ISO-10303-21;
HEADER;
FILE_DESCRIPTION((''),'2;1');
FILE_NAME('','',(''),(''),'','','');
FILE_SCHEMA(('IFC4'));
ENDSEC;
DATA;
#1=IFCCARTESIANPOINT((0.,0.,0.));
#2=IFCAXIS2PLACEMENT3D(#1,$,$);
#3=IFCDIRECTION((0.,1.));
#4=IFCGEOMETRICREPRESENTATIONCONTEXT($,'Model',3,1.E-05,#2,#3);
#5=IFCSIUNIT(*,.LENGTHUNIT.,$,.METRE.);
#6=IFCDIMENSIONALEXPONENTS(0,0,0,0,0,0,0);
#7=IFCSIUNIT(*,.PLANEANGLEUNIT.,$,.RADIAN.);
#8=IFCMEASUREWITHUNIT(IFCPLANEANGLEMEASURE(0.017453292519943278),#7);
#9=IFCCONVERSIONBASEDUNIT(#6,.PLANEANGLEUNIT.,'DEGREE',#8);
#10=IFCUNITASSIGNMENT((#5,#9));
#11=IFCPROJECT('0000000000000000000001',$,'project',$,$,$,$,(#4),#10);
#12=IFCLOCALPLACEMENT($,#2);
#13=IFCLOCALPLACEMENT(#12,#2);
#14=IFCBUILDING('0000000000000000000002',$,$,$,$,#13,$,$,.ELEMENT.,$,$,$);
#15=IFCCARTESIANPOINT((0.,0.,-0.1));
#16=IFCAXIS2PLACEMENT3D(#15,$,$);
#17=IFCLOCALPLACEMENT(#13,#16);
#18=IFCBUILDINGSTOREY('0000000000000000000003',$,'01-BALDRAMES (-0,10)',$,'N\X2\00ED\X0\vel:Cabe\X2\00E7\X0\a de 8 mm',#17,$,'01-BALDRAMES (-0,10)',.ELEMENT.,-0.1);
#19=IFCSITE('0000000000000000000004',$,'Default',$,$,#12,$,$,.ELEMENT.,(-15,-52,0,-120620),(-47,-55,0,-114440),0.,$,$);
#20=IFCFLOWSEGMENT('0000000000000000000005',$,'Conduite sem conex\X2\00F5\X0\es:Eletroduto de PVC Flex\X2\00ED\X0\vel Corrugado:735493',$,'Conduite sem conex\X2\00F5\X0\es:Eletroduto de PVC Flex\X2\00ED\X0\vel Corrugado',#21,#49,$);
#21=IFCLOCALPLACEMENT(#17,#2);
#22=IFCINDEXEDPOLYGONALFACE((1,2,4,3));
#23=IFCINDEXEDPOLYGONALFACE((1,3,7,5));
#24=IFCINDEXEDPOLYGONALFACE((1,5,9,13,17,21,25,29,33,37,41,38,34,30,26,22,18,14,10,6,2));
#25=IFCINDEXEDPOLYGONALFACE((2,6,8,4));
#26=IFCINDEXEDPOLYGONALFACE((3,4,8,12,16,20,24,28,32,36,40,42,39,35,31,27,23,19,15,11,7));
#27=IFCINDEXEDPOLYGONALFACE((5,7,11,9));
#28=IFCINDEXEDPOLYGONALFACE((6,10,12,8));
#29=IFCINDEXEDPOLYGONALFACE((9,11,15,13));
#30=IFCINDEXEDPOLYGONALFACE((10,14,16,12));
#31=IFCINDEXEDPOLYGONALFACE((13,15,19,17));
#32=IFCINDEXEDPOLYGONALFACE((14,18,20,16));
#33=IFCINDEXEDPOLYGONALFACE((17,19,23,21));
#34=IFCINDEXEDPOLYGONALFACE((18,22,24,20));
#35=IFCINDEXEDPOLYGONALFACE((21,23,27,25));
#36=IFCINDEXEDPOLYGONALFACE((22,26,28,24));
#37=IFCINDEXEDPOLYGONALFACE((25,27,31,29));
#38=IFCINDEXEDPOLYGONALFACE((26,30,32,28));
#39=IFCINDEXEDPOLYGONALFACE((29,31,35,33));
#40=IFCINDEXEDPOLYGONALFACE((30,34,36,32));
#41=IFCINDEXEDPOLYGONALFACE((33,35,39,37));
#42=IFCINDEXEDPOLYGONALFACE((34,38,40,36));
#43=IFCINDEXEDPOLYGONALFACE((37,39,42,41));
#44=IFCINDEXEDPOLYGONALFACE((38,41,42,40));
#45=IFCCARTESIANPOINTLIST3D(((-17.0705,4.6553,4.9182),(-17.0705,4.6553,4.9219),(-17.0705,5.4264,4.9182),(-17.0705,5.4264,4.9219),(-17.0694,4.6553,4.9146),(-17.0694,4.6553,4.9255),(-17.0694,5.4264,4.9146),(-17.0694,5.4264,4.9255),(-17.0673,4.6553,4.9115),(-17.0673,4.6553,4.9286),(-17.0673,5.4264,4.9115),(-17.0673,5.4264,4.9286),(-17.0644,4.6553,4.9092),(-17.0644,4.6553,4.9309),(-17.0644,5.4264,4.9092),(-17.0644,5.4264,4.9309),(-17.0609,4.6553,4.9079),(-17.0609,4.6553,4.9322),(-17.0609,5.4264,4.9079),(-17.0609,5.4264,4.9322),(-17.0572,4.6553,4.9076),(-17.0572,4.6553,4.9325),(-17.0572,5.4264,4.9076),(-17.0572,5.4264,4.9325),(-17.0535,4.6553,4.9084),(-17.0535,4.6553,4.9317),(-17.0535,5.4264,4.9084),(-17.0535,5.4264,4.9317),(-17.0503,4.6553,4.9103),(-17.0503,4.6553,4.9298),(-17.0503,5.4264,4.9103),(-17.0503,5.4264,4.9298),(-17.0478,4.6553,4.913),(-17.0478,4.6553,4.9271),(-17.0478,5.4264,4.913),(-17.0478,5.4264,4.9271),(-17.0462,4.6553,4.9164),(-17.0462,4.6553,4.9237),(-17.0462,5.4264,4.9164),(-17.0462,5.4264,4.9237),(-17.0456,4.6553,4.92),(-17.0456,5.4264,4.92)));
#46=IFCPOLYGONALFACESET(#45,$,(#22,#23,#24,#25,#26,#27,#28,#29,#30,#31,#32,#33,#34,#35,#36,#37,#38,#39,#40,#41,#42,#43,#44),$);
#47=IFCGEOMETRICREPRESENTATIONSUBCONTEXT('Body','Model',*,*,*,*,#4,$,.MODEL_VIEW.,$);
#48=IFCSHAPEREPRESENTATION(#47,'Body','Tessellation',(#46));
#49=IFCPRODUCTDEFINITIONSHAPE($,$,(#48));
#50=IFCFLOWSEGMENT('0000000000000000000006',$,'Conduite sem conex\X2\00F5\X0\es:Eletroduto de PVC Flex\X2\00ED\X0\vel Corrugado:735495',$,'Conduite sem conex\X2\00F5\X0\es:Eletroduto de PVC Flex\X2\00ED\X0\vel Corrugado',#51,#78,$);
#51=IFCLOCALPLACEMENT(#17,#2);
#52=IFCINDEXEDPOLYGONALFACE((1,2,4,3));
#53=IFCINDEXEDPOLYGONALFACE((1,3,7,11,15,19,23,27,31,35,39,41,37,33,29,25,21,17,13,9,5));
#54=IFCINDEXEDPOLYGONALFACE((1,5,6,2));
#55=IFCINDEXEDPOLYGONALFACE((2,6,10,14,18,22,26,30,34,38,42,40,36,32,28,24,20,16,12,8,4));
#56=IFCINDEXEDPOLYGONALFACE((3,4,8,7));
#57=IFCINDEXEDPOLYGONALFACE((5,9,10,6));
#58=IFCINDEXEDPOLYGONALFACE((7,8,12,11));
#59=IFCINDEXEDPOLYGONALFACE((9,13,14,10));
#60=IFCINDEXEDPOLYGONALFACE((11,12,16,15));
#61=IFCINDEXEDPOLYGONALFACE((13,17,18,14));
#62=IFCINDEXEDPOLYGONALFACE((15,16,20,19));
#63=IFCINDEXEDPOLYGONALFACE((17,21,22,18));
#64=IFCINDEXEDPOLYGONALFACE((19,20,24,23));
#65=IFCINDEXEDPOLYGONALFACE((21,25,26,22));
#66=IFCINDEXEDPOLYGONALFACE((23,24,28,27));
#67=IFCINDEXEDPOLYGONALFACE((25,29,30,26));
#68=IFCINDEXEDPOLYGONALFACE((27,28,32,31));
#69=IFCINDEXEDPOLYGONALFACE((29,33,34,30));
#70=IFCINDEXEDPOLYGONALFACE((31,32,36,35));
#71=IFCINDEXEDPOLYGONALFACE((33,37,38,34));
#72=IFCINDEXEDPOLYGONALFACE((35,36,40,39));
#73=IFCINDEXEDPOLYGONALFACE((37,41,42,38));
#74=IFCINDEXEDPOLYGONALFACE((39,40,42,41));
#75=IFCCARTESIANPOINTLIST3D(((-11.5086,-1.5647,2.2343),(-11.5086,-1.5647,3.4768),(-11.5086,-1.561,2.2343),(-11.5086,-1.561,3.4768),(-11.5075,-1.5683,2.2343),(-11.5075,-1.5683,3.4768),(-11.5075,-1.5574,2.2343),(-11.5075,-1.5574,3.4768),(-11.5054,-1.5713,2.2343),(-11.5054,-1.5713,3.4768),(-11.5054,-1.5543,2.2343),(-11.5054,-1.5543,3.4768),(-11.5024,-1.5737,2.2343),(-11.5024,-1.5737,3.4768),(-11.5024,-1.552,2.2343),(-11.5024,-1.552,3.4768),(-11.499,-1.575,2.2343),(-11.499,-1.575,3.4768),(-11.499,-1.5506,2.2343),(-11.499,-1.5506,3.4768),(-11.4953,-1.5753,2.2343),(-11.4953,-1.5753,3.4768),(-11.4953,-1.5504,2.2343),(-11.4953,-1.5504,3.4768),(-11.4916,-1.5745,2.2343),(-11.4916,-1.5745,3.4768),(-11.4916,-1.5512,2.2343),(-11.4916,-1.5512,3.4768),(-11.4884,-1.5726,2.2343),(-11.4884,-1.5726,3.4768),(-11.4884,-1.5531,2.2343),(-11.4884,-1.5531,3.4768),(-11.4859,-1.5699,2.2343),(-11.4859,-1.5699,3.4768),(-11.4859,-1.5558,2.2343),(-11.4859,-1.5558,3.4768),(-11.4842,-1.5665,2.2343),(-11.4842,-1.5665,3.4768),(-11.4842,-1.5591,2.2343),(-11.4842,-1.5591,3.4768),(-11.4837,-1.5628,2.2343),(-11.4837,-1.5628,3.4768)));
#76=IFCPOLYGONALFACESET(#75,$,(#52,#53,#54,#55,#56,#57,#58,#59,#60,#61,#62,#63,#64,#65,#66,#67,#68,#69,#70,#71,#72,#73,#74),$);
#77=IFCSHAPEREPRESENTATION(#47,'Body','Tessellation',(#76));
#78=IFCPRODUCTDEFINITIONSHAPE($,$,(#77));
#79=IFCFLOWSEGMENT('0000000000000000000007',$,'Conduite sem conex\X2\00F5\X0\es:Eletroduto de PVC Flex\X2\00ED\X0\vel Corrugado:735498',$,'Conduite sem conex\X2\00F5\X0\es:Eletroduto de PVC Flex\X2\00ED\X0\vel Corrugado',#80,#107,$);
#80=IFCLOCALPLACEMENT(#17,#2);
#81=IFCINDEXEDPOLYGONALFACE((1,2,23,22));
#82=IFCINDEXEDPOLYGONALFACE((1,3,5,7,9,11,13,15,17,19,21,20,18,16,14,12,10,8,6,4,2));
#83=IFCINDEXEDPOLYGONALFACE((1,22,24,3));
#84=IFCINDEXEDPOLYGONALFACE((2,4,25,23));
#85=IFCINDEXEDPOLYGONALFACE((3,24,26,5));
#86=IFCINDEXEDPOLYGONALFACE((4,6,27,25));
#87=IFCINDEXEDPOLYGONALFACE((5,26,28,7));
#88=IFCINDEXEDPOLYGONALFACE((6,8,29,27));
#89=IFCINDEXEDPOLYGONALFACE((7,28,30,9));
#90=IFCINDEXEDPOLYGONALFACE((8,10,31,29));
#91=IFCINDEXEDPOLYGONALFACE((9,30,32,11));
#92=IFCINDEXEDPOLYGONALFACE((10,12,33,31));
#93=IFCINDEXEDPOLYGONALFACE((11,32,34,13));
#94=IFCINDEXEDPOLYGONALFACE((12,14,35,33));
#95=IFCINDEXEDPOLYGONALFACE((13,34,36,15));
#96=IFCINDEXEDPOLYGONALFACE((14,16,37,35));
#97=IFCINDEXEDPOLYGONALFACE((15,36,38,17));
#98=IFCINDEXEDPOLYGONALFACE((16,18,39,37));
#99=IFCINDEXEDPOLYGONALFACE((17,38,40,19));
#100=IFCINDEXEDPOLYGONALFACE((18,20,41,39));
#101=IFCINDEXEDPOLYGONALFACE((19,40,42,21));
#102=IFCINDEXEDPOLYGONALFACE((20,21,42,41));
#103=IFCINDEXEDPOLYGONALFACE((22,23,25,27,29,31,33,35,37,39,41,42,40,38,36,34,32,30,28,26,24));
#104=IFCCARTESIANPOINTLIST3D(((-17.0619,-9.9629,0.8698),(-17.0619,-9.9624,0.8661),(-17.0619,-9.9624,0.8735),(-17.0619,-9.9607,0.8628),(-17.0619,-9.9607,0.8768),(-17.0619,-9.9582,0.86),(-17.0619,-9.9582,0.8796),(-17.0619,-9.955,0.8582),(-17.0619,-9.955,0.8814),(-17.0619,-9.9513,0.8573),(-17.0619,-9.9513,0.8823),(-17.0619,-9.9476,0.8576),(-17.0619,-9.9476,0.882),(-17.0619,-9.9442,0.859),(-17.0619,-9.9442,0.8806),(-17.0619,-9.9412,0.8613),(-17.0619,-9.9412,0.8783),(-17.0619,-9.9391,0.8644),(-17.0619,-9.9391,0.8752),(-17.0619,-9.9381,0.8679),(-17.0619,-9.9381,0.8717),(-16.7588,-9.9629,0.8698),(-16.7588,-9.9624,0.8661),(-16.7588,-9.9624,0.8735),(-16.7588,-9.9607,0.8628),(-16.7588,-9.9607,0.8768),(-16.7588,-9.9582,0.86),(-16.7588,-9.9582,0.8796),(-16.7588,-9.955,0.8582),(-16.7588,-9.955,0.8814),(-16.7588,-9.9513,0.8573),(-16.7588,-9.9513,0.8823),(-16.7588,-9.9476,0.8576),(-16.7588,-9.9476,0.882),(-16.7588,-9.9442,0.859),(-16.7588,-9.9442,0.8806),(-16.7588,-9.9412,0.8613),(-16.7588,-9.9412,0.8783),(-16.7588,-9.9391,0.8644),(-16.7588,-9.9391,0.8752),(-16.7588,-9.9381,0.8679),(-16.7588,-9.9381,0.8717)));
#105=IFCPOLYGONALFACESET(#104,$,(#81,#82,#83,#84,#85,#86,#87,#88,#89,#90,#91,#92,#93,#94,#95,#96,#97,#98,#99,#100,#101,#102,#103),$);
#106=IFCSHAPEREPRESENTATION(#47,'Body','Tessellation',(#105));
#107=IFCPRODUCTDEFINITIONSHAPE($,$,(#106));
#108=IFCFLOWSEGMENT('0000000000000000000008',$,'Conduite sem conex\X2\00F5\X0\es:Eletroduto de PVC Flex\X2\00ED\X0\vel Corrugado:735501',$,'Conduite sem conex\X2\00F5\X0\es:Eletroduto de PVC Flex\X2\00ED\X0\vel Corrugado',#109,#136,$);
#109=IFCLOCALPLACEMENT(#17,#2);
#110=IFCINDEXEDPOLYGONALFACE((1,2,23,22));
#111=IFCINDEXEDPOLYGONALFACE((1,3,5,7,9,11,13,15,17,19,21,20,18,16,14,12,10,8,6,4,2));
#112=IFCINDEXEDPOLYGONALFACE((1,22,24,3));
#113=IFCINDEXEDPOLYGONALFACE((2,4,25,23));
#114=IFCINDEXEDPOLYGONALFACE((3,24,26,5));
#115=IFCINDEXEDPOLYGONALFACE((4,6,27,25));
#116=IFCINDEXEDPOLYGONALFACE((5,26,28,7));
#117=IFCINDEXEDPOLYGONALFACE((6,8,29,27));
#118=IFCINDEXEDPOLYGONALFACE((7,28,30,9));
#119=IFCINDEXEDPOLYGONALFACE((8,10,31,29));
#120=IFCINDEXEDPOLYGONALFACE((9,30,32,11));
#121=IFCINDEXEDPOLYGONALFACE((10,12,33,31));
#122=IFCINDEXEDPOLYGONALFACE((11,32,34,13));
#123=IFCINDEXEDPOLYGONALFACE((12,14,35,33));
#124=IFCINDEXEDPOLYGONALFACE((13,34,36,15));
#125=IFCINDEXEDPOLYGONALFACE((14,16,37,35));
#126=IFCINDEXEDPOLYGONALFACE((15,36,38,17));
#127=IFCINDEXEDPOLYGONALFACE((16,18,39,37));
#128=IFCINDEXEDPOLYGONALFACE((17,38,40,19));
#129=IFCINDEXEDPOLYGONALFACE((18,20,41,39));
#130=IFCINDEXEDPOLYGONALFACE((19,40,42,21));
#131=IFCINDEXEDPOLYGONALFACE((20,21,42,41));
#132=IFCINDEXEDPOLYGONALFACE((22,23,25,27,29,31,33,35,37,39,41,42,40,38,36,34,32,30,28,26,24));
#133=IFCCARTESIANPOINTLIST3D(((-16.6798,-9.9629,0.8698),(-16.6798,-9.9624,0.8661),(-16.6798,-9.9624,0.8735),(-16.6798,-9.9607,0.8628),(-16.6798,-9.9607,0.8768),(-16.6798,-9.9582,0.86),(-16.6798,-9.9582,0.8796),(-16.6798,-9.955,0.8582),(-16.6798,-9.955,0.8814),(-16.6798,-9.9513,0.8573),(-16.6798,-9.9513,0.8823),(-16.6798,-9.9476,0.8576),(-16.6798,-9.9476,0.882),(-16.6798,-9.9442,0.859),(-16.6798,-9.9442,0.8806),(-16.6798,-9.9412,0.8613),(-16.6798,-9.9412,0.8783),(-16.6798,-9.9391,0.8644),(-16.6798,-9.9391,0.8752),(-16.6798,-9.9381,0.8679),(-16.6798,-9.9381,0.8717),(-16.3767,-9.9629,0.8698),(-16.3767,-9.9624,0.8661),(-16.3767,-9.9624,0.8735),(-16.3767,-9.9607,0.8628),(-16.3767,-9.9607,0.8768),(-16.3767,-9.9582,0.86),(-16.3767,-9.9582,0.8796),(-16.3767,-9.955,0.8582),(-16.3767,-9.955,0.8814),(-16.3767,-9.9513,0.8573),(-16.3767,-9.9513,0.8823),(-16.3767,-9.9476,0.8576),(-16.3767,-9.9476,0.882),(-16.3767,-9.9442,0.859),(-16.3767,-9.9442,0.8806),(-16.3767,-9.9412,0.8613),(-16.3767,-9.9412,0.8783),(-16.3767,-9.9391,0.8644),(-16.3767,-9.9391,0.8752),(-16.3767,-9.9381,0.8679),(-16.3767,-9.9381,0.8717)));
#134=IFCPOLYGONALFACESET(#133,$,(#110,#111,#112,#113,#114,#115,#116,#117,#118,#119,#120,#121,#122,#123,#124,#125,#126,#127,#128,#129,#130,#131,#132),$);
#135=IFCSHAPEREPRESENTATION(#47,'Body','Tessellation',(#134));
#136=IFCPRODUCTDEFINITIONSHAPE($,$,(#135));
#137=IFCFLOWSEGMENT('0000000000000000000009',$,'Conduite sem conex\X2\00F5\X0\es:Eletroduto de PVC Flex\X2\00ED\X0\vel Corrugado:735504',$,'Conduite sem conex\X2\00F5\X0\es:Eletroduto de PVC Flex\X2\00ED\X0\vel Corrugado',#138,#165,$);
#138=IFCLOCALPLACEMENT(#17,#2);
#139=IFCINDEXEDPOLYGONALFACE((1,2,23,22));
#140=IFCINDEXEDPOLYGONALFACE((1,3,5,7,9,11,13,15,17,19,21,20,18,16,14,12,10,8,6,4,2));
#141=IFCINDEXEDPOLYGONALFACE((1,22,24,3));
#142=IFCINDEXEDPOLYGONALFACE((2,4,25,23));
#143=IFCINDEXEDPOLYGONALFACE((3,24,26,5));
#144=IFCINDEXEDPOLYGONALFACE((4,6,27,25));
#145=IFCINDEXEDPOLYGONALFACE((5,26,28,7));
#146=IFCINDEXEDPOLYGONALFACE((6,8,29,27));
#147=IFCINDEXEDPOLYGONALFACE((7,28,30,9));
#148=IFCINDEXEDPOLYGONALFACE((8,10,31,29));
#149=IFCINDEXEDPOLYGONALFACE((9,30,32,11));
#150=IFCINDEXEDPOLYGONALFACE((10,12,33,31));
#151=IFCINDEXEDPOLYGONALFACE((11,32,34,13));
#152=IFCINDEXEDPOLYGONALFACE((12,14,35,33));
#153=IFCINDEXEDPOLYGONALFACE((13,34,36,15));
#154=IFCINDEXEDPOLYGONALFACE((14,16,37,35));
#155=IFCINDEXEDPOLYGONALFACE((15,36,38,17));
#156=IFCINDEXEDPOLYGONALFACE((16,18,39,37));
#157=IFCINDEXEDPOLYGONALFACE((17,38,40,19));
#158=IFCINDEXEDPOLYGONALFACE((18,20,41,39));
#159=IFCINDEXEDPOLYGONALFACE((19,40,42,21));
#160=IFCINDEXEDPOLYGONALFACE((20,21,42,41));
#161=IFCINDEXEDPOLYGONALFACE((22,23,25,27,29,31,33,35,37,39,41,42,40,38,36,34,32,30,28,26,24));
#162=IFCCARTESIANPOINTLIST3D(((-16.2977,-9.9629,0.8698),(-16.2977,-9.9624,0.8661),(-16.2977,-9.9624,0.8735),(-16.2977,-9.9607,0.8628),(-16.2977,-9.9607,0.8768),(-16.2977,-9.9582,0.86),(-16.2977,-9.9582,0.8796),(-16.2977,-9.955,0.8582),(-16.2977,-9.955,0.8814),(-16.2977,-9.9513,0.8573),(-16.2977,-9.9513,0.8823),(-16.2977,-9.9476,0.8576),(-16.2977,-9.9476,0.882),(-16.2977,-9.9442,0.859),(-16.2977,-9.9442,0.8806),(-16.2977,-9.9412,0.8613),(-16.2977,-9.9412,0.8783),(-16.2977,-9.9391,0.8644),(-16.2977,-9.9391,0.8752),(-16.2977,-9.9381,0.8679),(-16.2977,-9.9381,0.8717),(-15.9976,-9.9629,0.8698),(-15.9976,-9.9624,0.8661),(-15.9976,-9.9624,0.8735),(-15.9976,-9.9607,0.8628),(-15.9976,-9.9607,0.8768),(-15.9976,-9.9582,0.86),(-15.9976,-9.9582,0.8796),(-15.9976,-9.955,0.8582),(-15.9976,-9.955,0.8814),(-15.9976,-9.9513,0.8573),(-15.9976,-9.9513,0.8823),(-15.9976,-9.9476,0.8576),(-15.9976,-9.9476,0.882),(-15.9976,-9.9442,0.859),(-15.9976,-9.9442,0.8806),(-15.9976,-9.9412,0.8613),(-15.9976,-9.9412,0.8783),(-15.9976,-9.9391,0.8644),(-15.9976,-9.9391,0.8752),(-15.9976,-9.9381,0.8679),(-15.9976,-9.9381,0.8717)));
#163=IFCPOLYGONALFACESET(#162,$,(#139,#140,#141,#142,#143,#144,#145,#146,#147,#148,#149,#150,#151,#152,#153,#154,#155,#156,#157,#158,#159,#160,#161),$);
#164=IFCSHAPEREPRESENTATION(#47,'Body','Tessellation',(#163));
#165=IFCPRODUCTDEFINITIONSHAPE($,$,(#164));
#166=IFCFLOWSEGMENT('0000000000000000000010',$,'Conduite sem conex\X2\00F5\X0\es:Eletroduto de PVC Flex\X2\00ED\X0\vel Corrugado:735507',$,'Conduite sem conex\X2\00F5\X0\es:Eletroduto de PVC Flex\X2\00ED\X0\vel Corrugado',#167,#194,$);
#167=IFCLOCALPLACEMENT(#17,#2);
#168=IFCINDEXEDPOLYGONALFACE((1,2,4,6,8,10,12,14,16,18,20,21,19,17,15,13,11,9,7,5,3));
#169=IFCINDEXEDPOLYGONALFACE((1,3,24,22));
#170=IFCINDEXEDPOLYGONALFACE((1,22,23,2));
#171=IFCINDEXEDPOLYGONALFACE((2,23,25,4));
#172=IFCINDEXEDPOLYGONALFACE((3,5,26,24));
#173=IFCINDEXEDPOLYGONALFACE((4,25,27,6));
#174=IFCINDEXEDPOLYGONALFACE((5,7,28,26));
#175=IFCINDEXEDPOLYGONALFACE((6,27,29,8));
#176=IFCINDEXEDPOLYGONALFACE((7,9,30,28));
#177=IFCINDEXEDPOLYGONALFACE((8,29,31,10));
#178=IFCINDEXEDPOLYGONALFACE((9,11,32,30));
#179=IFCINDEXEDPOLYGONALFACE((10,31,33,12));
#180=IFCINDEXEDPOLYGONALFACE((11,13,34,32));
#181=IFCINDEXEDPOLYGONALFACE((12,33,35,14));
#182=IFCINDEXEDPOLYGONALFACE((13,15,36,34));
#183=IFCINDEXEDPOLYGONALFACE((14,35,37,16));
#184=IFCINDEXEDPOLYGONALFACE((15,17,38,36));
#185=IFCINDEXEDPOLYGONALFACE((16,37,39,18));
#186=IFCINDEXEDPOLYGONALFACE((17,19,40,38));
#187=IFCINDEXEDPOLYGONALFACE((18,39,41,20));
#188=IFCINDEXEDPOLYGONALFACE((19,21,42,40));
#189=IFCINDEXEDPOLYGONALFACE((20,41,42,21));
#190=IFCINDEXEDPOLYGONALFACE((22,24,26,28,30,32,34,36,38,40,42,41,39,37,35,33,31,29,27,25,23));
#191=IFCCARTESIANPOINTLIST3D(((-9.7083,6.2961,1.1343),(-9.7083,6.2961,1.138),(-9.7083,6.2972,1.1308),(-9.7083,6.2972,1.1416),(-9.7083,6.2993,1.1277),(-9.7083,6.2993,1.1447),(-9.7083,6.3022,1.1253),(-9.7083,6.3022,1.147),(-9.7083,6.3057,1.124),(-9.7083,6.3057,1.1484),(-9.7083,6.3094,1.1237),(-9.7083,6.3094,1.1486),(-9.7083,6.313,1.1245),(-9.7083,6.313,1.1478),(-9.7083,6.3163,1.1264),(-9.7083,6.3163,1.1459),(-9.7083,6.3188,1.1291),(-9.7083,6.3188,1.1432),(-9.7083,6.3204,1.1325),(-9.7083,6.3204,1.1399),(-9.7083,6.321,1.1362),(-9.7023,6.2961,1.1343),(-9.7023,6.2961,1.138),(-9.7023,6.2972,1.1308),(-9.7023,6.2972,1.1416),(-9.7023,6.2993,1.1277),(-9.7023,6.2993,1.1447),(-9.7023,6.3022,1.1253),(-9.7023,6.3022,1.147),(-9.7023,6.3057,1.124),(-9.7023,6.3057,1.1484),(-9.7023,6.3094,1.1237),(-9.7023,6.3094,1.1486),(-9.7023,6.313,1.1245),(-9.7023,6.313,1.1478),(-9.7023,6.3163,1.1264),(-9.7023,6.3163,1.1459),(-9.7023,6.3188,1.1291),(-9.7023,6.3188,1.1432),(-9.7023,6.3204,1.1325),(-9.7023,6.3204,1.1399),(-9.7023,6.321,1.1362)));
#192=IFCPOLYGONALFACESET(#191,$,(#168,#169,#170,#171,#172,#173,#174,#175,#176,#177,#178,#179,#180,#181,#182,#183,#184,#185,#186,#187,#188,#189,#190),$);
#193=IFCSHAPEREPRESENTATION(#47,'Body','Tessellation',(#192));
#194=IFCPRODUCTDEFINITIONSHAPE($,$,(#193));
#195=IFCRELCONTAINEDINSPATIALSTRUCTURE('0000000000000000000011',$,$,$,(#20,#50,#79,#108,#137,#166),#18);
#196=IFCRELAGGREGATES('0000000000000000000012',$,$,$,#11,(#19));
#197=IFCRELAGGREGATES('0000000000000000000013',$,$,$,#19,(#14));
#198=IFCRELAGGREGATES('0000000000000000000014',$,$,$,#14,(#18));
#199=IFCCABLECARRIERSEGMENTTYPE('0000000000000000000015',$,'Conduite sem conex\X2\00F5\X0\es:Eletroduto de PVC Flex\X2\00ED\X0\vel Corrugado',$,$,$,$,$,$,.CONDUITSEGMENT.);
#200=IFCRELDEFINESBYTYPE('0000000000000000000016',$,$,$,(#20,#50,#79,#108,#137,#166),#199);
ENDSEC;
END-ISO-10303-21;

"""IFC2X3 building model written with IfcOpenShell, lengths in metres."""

from ifc_helpers import new_model, entity, si_unit, converted_unit, direction, frame, origin, origin_2d_with_axis, place, context, subcontext, project, spatial, circle, extrude, type_object, element, save


model = new_model("IFC2X3")

# Units and contexts
model_context = context("Model", 3, precision=1e-05, world=origin(), true_north=direction((0.0, 1.0)))
body_context = subcontext(model_context, "Body", "Model", "MODEL_VIEW")
ifc_project = project(units=[si_unit("LENGTHUNIT", "METRE"), converted_unit("PLANEANGLEUNIT", "DEGREE", entity("IfcPlaneAngleMeasure", 0.017453292519943278), si_unit("PLANEANGLEUNIT", "RADIAN"), dimensions=[0, 0, 0, 0, 0, 0, 0])], contexts=[model_context])

# Site, building, storey
site_placement = place(None, origin())
site = spatial("IfcSite", under=ifc_project, at=site_placement, Name="Default", CompositionType="ELEMENT", RefLatitude=(-15, -52, 0, -120620), RefLongitude=(-47, -55, 0, -114440), RefElevation=0.0)
building_placement = place(site_placement, origin())
building = spatial("IfcBuilding", under=site, at=building_placement, CompositionType="ELEMENT")
storey_placement = place(building_placement, frame((0.0, 0.0, -0.1)))
storey = spatial("IfcBuildingStorey", under=building, at=storey_placement, Name="01-BALDRAMES (-0,10)", ObjectType="Nível:Cabeça de 8 mm", LongName="01-BALDRAMES (-0,10)", CompositionType="ELEMENT", Elevation=-0.1)

# Flow segments
cable_carrier_segment_type = type_object("IfcCableCarrierSegmentType", Name="Conduite sem conexões:Eletroduto de PVC Flexível Corrugado", PredefinedType="CONDUITSEGMENT")
flow_segment_1_placement = place(storey_placement, origin())
element("IfcFlowSegment", 1, at=flow_segment_1_placement, inside=storey, type_object=cable_carrier_segment_type, Name="Conduite sem conexões:Eletroduto de PVC Flexível Corrugado:735493", ObjectType="Conduite sem conexões:Eletroduto de PVC Flexível Corrugado", context=body_context, shape_type="SweptSolid", body=[
    extrude(circle(Radius=0.0125, at=origin_2d_with_axis()), frame((-17.0581, 4.6553, 4.92), z_axis=(0.0, 1.0, 0.0), x_axis=(1.0, 0.0, 0.0)), (0.0, 0.0, 1.0), 0.771),
])
flow_segment_2_placement = place(storey_placement, origin())
element("IfcFlowSegment", 2, at=flow_segment_2_placement, inside=storey, type_object=cable_carrier_segment_type, Name="Conduite sem conexões:Eletroduto de PVC Flexível Corrugado:735495", ObjectType="Conduite sem conexões:Eletroduto de PVC Flexível Corrugado", context=body_context, shape_type="SweptSolid", body=[
    extrude(circle(Radius=0.0125, at=origin_2d_with_axis()), frame((-11.4962, -1.5628, 2.2343)), (0.0, 0.0, 1.0), 1.2425),
])
flow_segment_3_placement = place(storey_placement, origin())
element("IfcFlowSegment", 3, at=flow_segment_3_placement, inside=storey, type_object=cable_carrier_segment_type, Name="Conduite sem conexões:Eletroduto de PVC Flexível Corrugado:735498", ObjectType="Conduite sem conexões:Eletroduto de PVC Flexível Corrugado", context=body_context, shape_type="SweptSolid", body=[
    extrude(circle(Radius=0.0125, at=origin_2d_with_axis()), frame((-17.0619, -9.9504, 0.8698), z_axis=(1.0, 0.0, 0.0), x_axis=(0.0, -1.0, 0.0)), (0.0, 0.0, 1.0), 0.3031),
])
flow_segment_4_placement = place(storey_placement, origin())
element("IfcFlowSegment", 4, at=flow_segment_4_placement, inside=storey, type_object=cable_carrier_segment_type, Name="Conduite sem conexões:Eletroduto de PVC Flexível Corrugado:735501", ObjectType="Conduite sem conexões:Eletroduto de PVC Flexível Corrugado", context=body_context, shape_type="SweptSolid", body=[
    extrude(circle(Radius=0.0125, at=origin_2d_with_axis()), frame((-16.6798, -9.9504, 0.8698), z_axis=(1.0, 0.0, 0.0), x_axis=(0.0, -1.0, 0.0)), (0.0, 0.0, 1.0), 0.3031),
])
flow_segment_5_placement = place(storey_placement, origin())
element("IfcFlowSegment", 5, at=flow_segment_5_placement, inside=storey, type_object=cable_carrier_segment_type, Name="Conduite sem conexões:Eletroduto de PVC Flexível Corrugado:735504", ObjectType="Conduite sem conexões:Eletroduto de PVC Flexível Corrugado", context=body_context, shape_type="SweptSolid", body=[
    extrude(circle(Radius=0.0125, at=origin_2d_with_axis()), frame((-16.2977, -9.9504, 0.8698), z_axis=(1.0, 0.0, 0.0), x_axis=(0.0, -1.0, 0.0)), (0.0, 0.0, 1.0), 0.3001),
])
flow_segment_6_placement = place(storey_placement, origin())
element("IfcFlowSegment", 6, at=flow_segment_6_placement, inside=storey, type_object=cable_carrier_segment_type, Name="Conduite sem conexões:Eletroduto de PVC Flexível Corrugado:735507", ObjectType="Conduite sem conexões:Eletroduto de PVC Flexível Corrugado", context=body_context, shape_type="SweptSolid", body=[
    extrude(circle(Radius=0.0125, at=origin_2d_with_axis()), frame((-9.7083, 6.3085, 1.1362), z_axis=(1.0, 0.0, 0.0), x_axis=(0.0, 1.0, 0.0)), (0.0, 0.0, 1.0), 0.0061),
])

save(model, "model.ifc")
